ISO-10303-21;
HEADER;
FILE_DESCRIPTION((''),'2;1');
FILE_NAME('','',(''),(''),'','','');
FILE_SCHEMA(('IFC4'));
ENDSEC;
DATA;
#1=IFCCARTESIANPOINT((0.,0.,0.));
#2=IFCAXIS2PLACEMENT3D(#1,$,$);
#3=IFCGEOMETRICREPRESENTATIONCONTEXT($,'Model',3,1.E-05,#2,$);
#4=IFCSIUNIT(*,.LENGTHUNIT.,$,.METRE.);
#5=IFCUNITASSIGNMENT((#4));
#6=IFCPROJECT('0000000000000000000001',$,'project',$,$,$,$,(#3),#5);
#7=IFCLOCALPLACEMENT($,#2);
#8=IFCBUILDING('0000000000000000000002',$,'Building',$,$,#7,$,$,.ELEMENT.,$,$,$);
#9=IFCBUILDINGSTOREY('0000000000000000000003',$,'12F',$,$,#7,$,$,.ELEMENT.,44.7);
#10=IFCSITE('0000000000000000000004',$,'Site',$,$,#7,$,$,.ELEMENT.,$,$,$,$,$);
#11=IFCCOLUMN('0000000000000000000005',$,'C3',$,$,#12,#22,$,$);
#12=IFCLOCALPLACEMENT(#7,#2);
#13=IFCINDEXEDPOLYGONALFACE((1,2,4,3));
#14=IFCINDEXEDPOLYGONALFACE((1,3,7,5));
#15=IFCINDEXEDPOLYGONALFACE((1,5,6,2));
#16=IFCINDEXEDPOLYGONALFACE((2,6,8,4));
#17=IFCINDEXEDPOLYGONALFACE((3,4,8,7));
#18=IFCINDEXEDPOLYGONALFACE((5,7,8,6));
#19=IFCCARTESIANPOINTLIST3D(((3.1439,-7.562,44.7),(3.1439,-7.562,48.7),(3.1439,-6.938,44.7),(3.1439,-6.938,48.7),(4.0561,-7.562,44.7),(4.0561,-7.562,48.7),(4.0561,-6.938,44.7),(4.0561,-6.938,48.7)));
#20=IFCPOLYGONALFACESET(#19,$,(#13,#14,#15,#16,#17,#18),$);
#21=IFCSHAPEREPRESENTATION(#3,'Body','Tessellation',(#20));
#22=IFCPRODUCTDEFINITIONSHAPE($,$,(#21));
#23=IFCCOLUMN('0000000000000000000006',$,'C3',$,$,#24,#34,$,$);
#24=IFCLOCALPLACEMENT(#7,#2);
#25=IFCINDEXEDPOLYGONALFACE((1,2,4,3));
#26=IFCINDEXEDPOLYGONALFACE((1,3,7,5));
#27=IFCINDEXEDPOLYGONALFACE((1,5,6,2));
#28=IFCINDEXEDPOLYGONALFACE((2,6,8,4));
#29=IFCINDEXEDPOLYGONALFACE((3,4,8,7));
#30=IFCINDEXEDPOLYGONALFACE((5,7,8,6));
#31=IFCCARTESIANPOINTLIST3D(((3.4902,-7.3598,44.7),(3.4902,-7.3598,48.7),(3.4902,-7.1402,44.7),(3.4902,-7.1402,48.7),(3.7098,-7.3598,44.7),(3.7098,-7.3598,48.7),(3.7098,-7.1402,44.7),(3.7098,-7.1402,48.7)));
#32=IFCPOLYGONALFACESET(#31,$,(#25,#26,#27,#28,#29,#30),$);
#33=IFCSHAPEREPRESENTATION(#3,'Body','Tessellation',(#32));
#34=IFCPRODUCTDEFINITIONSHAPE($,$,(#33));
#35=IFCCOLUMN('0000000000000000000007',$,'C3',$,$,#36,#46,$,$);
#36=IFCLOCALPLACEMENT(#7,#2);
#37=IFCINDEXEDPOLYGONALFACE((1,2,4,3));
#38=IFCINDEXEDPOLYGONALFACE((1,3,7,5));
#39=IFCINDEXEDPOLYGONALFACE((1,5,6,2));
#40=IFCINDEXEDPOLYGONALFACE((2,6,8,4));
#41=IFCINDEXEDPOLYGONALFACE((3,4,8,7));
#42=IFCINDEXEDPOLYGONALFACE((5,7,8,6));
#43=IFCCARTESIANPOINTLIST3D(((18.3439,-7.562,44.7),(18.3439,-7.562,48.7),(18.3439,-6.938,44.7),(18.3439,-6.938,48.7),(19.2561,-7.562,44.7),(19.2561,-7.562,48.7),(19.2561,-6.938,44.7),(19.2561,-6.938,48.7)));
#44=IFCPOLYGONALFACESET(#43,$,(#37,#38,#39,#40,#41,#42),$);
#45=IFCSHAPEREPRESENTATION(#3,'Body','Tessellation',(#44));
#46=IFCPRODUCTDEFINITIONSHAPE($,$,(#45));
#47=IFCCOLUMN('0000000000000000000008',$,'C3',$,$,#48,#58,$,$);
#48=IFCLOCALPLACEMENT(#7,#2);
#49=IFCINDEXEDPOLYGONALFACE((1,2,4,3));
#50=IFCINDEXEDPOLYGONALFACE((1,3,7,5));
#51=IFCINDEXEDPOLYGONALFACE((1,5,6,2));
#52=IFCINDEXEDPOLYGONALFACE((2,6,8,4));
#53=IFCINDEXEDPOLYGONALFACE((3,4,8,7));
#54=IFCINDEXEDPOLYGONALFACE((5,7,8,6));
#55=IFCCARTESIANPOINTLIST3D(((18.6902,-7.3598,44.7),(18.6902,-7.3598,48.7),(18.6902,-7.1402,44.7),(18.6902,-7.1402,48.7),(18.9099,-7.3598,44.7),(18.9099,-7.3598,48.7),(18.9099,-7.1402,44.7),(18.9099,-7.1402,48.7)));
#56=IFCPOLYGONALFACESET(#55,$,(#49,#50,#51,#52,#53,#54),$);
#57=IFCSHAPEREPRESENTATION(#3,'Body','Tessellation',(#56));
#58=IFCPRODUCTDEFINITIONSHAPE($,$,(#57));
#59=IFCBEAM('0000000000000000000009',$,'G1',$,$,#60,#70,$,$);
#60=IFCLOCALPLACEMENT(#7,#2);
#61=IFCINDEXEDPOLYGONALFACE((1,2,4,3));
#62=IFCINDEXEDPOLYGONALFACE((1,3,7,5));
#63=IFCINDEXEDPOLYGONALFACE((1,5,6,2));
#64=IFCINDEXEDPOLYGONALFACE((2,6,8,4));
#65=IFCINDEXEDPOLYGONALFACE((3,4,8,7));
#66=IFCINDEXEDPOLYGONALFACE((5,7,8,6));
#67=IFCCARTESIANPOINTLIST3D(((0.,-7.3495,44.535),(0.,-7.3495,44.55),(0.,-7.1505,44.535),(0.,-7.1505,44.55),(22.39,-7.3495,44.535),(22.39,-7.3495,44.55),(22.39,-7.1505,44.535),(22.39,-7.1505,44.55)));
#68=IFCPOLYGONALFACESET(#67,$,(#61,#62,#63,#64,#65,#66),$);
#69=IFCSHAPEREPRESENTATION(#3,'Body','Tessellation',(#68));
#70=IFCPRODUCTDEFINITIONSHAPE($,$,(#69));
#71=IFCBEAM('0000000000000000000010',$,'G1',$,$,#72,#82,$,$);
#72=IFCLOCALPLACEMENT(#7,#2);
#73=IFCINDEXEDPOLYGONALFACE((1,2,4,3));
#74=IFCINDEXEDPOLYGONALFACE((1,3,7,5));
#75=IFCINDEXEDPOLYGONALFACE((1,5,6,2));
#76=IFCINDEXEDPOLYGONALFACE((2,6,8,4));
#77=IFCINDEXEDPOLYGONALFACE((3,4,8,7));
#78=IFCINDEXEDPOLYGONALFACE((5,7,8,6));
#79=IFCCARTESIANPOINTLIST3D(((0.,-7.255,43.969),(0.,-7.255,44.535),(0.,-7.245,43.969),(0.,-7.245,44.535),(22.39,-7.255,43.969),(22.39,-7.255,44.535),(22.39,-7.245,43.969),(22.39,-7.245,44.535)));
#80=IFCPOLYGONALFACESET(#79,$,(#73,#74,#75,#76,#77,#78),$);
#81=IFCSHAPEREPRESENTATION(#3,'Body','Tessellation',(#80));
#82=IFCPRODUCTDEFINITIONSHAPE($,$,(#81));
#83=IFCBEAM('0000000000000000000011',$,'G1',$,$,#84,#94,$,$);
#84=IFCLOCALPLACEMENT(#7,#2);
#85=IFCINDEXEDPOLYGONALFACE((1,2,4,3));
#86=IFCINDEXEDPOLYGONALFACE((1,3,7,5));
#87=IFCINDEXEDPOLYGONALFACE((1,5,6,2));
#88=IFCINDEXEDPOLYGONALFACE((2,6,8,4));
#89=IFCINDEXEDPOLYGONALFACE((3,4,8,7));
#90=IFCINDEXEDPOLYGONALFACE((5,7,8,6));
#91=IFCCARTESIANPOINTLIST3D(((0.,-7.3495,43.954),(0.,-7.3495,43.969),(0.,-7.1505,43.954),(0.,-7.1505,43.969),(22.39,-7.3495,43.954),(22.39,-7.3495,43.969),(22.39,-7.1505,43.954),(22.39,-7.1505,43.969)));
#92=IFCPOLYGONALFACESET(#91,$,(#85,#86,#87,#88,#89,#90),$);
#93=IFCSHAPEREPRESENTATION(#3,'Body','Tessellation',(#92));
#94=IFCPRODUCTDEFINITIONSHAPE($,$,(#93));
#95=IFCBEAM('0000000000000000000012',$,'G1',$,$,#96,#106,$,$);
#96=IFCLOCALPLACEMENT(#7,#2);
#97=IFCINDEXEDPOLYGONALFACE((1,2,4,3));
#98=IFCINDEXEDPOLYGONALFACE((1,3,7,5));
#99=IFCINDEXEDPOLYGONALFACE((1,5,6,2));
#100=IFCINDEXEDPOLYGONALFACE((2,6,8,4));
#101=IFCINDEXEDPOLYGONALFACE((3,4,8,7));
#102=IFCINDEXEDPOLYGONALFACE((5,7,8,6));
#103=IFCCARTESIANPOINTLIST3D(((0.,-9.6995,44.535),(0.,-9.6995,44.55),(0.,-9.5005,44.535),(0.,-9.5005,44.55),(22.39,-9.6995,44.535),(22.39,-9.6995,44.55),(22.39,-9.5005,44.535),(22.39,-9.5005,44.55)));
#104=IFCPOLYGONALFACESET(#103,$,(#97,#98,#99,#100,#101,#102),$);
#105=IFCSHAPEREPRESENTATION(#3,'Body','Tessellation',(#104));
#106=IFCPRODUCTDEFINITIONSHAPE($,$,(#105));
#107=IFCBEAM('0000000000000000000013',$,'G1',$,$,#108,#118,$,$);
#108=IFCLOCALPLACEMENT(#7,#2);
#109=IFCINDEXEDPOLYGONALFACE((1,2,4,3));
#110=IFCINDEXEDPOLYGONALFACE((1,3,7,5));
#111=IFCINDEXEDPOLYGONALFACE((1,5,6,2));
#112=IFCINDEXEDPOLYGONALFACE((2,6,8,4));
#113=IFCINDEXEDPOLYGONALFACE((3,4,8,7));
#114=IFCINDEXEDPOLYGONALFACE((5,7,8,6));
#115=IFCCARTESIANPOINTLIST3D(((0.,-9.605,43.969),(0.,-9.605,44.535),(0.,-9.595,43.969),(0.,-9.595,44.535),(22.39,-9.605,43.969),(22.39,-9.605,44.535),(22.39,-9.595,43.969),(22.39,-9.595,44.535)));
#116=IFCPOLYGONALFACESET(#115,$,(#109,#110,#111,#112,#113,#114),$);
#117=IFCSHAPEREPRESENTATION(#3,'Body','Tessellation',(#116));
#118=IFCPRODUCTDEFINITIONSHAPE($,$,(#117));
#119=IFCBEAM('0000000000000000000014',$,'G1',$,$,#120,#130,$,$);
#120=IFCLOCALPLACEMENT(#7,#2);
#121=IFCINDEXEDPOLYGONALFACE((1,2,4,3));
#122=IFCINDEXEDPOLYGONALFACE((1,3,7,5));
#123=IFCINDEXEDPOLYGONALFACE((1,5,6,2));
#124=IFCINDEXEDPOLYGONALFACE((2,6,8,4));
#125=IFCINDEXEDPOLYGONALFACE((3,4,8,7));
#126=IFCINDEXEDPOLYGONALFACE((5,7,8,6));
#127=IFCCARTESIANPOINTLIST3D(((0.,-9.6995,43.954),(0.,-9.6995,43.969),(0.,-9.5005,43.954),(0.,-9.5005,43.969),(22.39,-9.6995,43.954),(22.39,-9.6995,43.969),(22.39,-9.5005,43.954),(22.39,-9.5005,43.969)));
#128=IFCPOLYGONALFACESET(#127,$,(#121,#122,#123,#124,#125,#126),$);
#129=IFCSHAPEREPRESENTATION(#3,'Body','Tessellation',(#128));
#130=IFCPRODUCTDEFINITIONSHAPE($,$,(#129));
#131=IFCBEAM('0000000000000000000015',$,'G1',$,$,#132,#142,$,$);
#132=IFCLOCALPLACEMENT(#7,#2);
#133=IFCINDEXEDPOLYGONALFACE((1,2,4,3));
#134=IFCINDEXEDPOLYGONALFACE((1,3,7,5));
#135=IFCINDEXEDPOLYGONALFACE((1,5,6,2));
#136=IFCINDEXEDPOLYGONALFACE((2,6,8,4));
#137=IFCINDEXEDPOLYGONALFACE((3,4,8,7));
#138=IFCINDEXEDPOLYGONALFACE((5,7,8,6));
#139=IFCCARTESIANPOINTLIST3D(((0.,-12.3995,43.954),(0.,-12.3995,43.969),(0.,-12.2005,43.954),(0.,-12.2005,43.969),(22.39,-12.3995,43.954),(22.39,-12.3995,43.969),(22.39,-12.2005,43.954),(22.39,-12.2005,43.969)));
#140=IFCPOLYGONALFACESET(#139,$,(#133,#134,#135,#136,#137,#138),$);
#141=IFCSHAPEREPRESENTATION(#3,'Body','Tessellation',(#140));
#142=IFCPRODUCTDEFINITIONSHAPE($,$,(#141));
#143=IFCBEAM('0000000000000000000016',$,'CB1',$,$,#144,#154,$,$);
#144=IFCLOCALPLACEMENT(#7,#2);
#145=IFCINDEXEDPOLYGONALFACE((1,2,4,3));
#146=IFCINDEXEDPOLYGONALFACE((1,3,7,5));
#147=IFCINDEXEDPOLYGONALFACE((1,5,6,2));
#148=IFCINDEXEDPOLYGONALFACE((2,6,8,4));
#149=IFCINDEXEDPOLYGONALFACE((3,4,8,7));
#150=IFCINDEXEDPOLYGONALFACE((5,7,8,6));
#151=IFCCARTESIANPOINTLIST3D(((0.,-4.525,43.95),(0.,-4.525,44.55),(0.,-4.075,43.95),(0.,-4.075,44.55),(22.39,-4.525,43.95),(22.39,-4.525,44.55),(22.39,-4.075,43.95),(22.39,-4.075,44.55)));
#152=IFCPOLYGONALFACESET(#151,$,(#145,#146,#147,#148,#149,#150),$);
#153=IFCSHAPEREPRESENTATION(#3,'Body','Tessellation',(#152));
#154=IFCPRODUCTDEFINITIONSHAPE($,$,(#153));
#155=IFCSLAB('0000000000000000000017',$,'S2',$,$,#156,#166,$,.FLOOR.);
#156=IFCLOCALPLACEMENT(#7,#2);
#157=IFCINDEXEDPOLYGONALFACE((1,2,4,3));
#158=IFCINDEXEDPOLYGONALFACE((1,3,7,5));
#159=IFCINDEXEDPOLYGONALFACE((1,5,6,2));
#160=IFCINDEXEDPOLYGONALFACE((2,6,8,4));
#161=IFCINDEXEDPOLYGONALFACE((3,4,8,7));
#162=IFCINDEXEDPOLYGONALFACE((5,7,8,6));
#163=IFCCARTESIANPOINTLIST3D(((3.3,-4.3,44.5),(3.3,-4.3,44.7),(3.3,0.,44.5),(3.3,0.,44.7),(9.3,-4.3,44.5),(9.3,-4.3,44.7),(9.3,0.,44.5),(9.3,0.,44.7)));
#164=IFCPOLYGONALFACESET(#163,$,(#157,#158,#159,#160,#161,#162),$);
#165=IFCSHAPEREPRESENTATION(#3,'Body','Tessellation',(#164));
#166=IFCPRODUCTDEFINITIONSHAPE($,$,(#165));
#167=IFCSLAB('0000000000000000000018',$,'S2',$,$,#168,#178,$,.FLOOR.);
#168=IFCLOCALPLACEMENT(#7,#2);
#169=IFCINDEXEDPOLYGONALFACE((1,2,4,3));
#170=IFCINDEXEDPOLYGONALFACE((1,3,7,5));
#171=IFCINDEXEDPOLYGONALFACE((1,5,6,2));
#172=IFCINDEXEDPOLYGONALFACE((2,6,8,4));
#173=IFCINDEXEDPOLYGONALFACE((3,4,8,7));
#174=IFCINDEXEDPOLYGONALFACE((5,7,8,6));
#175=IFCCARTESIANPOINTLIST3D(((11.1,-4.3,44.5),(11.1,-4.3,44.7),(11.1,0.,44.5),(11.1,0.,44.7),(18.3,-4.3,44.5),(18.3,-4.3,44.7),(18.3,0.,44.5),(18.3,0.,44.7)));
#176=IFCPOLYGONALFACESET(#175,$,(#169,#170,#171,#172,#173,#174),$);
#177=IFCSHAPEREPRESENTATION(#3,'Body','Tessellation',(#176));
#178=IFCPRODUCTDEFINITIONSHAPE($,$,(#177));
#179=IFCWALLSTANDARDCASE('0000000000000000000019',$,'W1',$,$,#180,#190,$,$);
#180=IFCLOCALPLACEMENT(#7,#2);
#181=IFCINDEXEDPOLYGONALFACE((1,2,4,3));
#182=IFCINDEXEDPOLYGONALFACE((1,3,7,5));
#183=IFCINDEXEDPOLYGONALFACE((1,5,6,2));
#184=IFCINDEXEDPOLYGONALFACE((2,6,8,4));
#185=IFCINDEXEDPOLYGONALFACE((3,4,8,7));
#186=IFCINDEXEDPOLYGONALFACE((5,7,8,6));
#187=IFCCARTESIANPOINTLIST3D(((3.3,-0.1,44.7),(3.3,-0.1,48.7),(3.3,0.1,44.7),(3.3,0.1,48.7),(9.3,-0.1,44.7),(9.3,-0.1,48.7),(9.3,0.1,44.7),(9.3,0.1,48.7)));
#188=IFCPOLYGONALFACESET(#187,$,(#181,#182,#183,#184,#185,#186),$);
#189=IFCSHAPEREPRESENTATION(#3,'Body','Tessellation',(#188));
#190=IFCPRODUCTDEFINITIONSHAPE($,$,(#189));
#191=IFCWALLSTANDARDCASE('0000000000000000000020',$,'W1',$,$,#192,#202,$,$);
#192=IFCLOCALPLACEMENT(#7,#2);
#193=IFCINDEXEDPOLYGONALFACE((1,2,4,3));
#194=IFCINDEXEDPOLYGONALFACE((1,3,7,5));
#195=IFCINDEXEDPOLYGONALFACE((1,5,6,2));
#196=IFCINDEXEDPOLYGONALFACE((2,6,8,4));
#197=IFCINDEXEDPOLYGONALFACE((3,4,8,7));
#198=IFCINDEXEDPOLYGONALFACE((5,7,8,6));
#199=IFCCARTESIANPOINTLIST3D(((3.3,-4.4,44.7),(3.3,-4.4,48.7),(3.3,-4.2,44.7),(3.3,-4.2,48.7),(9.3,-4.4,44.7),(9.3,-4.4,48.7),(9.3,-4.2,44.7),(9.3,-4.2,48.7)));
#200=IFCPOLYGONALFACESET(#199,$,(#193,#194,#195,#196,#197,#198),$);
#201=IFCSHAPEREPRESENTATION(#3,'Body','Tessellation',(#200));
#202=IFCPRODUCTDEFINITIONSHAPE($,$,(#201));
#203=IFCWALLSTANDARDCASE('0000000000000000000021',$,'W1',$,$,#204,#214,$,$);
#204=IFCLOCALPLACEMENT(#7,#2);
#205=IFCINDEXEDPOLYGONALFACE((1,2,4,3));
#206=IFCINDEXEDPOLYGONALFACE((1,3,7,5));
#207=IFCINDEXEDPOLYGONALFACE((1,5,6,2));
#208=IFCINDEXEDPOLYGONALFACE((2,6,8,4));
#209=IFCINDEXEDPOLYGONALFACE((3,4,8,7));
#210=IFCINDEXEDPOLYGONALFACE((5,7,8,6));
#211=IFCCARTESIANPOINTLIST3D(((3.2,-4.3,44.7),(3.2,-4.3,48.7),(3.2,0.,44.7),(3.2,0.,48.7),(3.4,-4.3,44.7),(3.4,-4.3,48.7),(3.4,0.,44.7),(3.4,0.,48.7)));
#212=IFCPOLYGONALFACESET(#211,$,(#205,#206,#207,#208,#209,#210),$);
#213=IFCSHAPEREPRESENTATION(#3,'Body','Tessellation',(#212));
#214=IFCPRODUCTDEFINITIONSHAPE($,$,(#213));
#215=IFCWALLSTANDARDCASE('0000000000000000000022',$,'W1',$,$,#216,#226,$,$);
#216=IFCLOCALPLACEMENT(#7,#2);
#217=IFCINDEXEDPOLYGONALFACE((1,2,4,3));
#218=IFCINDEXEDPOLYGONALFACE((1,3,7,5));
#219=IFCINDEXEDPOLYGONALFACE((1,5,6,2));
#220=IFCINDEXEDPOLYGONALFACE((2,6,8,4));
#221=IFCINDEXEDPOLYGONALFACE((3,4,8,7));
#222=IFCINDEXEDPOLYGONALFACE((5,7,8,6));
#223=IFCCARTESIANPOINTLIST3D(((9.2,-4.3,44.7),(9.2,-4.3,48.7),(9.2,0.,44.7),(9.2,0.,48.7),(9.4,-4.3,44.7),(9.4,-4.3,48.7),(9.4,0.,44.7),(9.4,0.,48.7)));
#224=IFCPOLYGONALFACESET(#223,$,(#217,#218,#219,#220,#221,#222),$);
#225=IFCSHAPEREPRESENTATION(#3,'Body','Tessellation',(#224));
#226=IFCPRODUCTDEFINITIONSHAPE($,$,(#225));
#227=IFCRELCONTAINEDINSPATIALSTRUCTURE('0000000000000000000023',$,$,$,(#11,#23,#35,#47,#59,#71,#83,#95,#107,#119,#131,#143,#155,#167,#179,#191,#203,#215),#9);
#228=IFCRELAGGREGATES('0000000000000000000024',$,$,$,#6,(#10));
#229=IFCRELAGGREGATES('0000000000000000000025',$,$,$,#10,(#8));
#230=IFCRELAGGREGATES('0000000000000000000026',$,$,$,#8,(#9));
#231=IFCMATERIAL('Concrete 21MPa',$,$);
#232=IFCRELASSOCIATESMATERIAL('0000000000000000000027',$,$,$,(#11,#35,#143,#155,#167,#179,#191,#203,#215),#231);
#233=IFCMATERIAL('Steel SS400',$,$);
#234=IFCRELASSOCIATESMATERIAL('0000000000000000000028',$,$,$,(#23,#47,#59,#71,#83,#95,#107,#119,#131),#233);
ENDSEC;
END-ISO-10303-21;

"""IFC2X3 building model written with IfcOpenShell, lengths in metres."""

from ifc_helpers import new_model, si_unit, frame, origin, origin_2d, place, context, project, spatial, rectangle, extrude, material, element, save


model = new_model("IFC2X3")

# Units and contexts
model_context = context("Model", 3, precision=1e-05, world=origin())
ifc_project = project(units=[si_unit("LENGTHUNIT", "METRE")], contexts=[model_context])

# Site, building, storey
placement = place(None, origin())
site = spatial("IfcSite", under=ifc_project, at=placement, Name="Site", CompositionType="ELEMENT")
building = spatial("IfcBuilding", under=site, at=placement, Name="Building", CompositionType="ELEMENT")
storey = spatial("IfcBuildingStorey", under=building, at=placement, Name="12F", CompositionType="ELEMENT", Elevation=44.7)

# Columns
ifc_material_1 = material(Name="Concrete 21MPa")
column_1_placement = place(None, frame((3.6, -7.25, 44.7)))
element("IfcColumn", 1, at=column_1_placement, inside=storey, material=ifc_material_1, Name="C3", context=model_context, shape_type="SweptSolid", body=[
    extrude(rectangle(XDim=0.9121, YDim=0.6241, at=origin_2d()), origin(), (0.0, 0.0, 1.0), 4.0),
])
ifc_material_2 = material(Name="Steel SS400")
column_2_placement = place(None, frame((3.6, -7.25, 44.7)))
element("IfcColumn", 2, at=column_2_placement, inside=storey, material=ifc_material_2, Name="C3", context=model_context, shape_type="SweptSolid", body=[
    extrude(rectangle(XDim=0.2197, YDim=0.2197, at=origin_2d()), origin(), (0.0, 0.0, 1.0), 4.0),
])
column_3_placement = place(None, frame((18.8, -7.25, 44.7)))
element("IfcColumn", 3, at=column_3_placement, inside=storey, material=ifc_material_1, Name="C3", context=model_context, shape_type="SweptSolid", body=[
    extrude(rectangle(XDim=0.9121, YDim=0.6241, at=origin_2d()), origin(), (0.0, 0.0, 1.0), 4.0),
])
column_4_placement = place(None, frame((18.8, -7.25, 44.7)))
element("IfcColumn", 4, at=column_4_placement, inside=storey, material=ifc_material_2, Name="C3", context=model_context, shape_type="SweptSolid", body=[
    extrude(rectangle(XDim=0.2197, YDim=0.2197, at=origin_2d()), origin(), (0.0, 0.0, 1.0), 4.0),
])

# Beams
beam_1_placement = place(None, frame((11.195, -7.25, 44.535)))
element("IfcBeam", 5, at=beam_1_placement, inside=storey, material=ifc_material_2, Name="G1", context=model_context, shape_type="SweptSolid", body=[
    extrude(rectangle(XDim=22.39, YDim=0.199, at=origin_2d()), origin(), (0.0, 0.0, 1.0), 0.015),
])
beam_2_placement = place(None, frame((11.195, -7.25, 43.969)))
element("IfcBeam", 6, at=beam_2_placement, inside=storey, material=ifc_material_2, Name="G1", context=model_context, shape_type="SweptSolid", body=[
    extrude(rectangle(XDim=22.39, YDim=0.01, at=origin_2d()), origin(), (0.0, 0.0, 1.0), 0.566),
])
for number, where, name in (
    (7, (11.195, -7.25, 43.954), "G1"),
    (8, (11.195, -9.6, 44.535), "G1"),
):
    element("IfcBeam", number, at=place(None, frame(where)), inside=storey, material=ifc_material_2, Name=name, context=model_context, shape_type="SweptSolid", body=[
        extrude(rectangle(XDim=22.39, YDim=0.199, at=origin_2d()), origin(), (0.0, 0.0, 1.0), 0.015),
    ])
beam_3_placement = place(None, frame((11.195, -9.6, 43.969)))
element("IfcBeam", 9, at=beam_3_placement, inside=storey, material=ifc_material_2, Name="G1", context=model_context, shape_type="SweptSolid", body=[
    extrude(rectangle(XDim=22.39, YDim=0.01, at=origin_2d()), origin(), (0.0, 0.0, 1.0), 0.566),
])
for number, where, name in (
    (10, (11.195, -9.6, 43.954), "G1"),
    (11, (11.195, -12.3, 43.954), "G1"),
):
    element("IfcBeam", number, at=place(None, frame(where)), inside=storey, material=ifc_material_2, Name=name, context=model_context, shape_type="SweptSolid", body=[
        extrude(rectangle(XDim=22.39, YDim=0.199, at=origin_2d()), origin(), (0.0, 0.0, 1.0), 0.015),
    ])
beam_4_placement = place(None, frame((11.195, -4.3, 43.95)))
element("IfcBeam", 12, at=beam_4_placement, inside=storey, material=ifc_material_1, Name="CB1", context=model_context, shape_type="SweptSolid", body=[
    extrude(rectangle(XDim=22.39, YDim=0.45, at=origin_2d()), origin(), (0.0, 0.0, 1.0), 0.6),
])

# Slabs
slab_1_placement = place(None, frame((6.3, -2.15, 44.5)))
element("IfcSlab", 13, at=slab_1_placement, inside=storey, material=ifc_material_1, Name="S2", PredefinedType="FLOOR", context=model_context, shape_type="SweptSolid", body=[
    extrude(rectangle(XDim=6.0, YDim=4.3, at=origin_2d()), origin(), (0.0, 0.0, 1.0), 0.2),
])
slab_2_placement = place(None, frame((14.7, -2.15, 44.5)))
element("IfcSlab", 14, at=slab_2_placement, inside=storey, material=ifc_material_1, Name="S2", PredefinedType="FLOOR", context=model_context, shape_type="SweptSolid", body=[
    extrude(rectangle(XDim=7.2, YDim=4.3, at=origin_2d()), origin(), (0.0, 0.0, 1.0), 0.2),
])

# Walls
for number, where, name in (
    (15, (6.3, 0.0, 44.7), "W1"),
    (16, (6.3, -4.3, 44.7), "W1"),
):
    element("IfcWallStandardCase", number, at=place(None, frame(where)), inside=storey, material=ifc_material_1, Name=name, context=model_context, shape_type="SweptSolid", body=[
        extrude(rectangle(XDim=6.0, YDim=0.2, at=origin_2d()), origin(), (0.0, 0.0, 1.0), 4.0),
    ])
for number, where, name in (
    (17, (3.3, -2.15, 44.7), "W1"),
    (18, (9.3, -2.15, 44.7), "W1"),
):
    element("IfcWallStandardCase", number, at=place(None, frame(where)), inside=storey, material=ifc_material_1, Name=name, context=model_context, shape_type="SweptSolid", body=[
        extrude(rectangle(XDim=0.2, YDim=4.3, at=origin_2d()), origin(), (0.0, 0.0, 1.0), 4.0),
    ])

save(model, "model.ifc")
